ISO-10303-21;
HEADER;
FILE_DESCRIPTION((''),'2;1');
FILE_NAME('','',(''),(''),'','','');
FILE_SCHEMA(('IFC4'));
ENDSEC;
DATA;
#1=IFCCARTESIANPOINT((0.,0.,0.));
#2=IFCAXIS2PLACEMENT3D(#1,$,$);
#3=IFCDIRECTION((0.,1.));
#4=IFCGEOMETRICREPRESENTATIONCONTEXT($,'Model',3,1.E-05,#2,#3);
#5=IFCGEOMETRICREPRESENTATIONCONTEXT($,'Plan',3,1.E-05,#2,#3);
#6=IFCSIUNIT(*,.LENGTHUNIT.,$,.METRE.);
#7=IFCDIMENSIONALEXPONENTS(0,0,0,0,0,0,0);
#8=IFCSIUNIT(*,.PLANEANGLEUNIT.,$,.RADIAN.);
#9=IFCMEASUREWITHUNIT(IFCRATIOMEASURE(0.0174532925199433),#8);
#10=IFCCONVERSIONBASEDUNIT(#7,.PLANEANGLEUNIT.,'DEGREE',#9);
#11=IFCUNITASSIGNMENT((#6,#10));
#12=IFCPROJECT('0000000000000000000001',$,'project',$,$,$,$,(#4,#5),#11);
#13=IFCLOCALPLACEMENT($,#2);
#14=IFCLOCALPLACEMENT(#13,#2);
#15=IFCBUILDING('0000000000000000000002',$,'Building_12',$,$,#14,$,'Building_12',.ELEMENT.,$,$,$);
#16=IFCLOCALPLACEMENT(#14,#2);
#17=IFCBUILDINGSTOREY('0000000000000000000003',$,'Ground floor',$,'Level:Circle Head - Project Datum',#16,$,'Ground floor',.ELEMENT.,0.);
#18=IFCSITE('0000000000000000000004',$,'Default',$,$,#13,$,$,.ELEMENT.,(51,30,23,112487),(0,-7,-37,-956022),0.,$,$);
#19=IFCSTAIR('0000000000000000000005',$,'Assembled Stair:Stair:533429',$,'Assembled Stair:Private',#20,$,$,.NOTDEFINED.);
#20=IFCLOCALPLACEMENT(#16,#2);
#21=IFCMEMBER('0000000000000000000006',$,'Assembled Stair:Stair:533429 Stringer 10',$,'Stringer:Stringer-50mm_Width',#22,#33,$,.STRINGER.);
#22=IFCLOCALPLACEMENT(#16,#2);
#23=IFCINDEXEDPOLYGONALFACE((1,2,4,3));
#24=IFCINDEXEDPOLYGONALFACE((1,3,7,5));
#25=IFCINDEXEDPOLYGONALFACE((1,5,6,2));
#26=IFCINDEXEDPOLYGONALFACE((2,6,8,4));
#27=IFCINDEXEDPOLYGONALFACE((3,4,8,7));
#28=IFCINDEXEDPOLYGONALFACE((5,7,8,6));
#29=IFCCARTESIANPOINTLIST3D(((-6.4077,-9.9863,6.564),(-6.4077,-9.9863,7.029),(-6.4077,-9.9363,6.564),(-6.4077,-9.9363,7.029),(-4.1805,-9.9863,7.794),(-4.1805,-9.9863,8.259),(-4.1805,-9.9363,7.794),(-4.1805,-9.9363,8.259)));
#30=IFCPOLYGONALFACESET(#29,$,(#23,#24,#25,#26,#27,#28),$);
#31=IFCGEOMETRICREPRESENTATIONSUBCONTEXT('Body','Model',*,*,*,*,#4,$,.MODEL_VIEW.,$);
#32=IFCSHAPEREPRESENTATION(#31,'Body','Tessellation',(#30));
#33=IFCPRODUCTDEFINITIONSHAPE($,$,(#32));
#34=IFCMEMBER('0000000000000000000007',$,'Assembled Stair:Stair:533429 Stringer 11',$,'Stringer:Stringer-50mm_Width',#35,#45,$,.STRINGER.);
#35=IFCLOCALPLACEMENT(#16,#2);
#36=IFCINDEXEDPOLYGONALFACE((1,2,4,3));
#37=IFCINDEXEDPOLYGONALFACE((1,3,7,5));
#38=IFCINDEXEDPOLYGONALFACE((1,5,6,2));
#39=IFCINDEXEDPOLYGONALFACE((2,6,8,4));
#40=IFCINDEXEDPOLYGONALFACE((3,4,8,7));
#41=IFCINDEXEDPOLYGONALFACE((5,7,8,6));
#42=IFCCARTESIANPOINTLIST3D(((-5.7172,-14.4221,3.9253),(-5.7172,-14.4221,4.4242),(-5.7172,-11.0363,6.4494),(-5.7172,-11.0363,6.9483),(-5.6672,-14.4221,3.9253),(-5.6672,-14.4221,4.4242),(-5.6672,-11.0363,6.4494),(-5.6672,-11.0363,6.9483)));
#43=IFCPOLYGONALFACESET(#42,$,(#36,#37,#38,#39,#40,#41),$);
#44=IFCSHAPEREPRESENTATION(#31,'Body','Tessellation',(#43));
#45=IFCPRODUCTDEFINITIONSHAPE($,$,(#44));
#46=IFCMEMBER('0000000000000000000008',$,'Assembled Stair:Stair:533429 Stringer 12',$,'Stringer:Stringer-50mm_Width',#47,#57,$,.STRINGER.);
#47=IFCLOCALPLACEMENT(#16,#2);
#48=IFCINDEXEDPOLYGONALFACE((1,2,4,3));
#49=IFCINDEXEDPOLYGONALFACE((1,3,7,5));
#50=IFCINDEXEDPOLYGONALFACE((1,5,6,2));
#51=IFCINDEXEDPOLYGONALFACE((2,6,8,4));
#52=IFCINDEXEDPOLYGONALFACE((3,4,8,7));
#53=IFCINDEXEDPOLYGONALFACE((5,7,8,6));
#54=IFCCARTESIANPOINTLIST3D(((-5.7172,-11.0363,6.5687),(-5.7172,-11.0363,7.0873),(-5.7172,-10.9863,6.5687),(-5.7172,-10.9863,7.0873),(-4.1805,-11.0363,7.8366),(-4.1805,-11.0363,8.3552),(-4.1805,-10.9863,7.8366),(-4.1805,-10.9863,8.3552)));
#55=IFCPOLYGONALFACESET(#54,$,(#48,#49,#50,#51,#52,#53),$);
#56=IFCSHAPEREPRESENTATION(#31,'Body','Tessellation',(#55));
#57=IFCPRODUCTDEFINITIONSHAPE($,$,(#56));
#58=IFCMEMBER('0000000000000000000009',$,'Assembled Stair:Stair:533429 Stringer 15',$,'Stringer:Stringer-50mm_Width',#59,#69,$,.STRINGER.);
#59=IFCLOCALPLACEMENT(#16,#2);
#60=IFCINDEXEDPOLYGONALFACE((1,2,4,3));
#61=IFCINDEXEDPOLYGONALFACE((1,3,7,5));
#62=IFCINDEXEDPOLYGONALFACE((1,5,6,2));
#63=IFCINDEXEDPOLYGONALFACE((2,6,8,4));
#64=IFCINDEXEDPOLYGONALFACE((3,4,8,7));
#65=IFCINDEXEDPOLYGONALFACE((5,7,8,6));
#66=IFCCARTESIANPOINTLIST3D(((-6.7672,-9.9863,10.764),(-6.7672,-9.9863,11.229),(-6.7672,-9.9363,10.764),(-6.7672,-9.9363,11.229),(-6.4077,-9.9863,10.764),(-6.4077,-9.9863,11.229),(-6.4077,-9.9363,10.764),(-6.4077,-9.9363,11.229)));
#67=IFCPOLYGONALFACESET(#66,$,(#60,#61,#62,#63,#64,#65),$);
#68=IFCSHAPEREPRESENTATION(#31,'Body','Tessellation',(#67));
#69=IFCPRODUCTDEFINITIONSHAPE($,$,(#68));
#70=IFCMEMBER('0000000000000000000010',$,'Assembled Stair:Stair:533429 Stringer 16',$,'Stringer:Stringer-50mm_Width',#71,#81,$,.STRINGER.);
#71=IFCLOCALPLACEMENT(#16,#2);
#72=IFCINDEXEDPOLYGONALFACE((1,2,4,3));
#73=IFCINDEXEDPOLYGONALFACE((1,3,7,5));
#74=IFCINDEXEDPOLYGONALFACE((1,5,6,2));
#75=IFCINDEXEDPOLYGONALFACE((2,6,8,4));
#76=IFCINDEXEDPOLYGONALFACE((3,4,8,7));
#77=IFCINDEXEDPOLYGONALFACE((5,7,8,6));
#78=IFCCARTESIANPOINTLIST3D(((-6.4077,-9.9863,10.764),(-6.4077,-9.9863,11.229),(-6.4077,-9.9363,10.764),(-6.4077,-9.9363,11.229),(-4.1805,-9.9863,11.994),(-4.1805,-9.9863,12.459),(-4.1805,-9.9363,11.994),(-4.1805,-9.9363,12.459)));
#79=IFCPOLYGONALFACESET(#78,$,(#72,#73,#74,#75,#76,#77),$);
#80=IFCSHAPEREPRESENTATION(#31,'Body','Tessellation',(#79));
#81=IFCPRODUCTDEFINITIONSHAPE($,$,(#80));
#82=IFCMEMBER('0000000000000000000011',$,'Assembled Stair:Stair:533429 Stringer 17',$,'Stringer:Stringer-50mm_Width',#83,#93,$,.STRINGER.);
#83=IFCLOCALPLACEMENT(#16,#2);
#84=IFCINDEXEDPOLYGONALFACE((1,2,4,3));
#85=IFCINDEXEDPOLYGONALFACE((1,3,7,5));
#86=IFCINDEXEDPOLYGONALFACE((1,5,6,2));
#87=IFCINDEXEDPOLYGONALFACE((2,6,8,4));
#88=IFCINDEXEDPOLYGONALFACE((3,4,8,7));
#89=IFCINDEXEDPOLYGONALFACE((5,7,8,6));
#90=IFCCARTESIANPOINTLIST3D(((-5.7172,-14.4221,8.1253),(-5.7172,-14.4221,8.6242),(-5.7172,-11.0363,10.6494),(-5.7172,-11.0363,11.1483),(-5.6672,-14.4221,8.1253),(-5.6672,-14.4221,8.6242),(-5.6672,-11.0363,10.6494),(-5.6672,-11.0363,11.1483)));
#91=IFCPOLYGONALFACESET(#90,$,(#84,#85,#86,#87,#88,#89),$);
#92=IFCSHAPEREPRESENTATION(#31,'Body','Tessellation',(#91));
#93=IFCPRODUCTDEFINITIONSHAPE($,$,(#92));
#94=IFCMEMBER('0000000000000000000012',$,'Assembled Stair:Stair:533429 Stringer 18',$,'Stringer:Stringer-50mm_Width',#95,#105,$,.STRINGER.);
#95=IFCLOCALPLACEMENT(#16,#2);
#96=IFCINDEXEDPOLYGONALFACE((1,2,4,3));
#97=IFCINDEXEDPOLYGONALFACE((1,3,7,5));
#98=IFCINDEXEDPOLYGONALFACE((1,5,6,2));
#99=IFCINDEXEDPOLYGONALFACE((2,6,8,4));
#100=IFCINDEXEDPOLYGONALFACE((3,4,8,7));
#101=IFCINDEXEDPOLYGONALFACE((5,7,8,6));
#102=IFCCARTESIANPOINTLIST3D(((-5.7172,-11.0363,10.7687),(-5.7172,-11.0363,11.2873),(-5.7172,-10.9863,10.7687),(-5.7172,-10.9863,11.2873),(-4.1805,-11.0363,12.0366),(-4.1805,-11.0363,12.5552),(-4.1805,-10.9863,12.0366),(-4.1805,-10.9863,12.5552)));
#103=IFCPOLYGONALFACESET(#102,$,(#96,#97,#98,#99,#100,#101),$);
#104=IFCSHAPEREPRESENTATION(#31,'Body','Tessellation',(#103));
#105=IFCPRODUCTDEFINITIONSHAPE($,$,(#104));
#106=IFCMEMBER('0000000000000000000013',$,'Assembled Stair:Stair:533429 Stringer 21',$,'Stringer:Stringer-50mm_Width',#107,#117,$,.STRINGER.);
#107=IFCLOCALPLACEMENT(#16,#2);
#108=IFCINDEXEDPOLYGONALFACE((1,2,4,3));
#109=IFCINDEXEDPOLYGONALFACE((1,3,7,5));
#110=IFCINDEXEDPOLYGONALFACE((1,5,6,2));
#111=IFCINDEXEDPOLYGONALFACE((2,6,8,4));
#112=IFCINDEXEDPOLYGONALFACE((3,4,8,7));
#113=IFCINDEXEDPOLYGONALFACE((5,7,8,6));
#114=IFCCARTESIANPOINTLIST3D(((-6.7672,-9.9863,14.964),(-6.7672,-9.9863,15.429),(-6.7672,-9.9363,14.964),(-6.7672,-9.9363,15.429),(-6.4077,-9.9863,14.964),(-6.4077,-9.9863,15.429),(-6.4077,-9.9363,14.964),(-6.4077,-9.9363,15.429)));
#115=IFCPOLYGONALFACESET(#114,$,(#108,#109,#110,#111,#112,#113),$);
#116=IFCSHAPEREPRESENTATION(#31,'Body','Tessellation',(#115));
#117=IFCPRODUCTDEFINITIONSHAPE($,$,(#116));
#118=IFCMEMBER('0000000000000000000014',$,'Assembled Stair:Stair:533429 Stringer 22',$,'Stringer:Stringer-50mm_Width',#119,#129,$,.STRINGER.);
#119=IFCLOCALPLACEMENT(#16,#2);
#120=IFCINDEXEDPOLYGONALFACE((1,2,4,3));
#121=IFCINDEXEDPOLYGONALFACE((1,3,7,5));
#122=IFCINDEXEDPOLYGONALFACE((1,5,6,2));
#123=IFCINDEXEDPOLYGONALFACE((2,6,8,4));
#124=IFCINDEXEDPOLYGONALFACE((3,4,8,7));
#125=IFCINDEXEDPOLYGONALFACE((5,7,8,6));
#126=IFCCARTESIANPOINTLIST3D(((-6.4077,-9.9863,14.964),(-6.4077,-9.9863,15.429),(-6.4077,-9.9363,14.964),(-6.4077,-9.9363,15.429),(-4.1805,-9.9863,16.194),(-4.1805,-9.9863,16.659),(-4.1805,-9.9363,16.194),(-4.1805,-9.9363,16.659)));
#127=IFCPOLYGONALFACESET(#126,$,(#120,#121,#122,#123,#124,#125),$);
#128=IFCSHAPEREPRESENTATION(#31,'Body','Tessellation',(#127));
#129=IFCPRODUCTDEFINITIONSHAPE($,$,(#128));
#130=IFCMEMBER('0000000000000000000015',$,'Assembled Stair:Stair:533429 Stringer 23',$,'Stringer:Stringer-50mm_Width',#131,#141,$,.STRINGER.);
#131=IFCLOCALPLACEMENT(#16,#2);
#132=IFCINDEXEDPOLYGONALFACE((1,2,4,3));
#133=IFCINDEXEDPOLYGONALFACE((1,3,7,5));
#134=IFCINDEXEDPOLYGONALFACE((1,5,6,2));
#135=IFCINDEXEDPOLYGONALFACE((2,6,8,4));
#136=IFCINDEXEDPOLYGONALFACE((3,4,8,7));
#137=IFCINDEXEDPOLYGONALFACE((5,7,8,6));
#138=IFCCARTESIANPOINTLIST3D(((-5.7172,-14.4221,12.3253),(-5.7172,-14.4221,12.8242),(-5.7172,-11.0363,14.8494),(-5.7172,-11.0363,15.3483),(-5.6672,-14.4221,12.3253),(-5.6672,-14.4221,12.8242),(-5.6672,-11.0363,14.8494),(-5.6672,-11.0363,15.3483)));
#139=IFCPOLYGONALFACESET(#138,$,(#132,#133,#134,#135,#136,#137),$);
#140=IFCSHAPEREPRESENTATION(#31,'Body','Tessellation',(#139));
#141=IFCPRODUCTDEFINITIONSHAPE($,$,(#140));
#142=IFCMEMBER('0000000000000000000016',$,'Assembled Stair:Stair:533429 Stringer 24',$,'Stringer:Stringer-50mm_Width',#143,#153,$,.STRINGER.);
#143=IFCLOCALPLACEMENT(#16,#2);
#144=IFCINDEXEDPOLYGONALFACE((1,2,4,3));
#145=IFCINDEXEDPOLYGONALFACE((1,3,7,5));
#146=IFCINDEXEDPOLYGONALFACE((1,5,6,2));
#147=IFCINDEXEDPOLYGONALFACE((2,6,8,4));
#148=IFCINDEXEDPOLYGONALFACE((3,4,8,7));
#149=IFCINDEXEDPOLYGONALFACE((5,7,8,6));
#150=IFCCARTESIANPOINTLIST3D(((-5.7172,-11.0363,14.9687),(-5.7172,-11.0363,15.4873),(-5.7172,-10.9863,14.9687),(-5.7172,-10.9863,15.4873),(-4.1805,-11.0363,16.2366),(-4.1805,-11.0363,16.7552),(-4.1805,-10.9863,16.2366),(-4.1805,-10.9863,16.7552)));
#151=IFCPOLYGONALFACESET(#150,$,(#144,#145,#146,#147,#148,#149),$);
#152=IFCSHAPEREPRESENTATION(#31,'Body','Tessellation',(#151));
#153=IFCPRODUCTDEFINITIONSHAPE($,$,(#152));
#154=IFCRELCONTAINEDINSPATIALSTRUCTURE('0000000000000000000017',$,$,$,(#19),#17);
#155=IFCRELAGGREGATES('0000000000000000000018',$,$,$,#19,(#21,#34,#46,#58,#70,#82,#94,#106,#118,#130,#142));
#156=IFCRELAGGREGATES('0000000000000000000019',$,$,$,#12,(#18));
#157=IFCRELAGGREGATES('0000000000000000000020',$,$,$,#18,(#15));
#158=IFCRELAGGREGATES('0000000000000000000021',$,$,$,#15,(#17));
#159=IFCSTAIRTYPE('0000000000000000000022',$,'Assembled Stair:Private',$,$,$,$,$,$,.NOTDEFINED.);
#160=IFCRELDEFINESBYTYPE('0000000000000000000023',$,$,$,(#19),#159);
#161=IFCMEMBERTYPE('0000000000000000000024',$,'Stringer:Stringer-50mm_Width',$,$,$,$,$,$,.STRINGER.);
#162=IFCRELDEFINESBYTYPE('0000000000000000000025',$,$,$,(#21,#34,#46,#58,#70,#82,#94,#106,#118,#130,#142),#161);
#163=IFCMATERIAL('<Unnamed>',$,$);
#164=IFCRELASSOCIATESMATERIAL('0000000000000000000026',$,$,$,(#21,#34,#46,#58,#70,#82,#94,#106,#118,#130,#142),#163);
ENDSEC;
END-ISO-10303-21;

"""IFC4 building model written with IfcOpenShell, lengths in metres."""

from ifc_helpers import new_model, entity, si_unit, converted_unit, direction, frame, origin, place, context, subcontext, project, spatial, indexed_curve, outline, extrude, material, type_object, element, aggregate, save


model = new_model("IFC4")

# Units and contexts
model_context = context("Model", 3, precision=1e-05, world=origin(), true_north=direction((0.0, 1.0)))
plan_context = context("Plan", 3, precision=1e-05, world=origin(), true_north=direction((0.0, 1.0)))
body_context = subcontext(model_context, "Body", "Model", "MODEL_VIEW")
ifc_project = project(units=[si_unit("LENGTHUNIT", "METRE"), converted_unit("PLANEANGLEUNIT", "DEGREE", entity("IfcRatioMeasure", 0.0174532925199433), si_unit("PLANEANGLEUNIT", "RADIAN"), dimensions=[0, 0, 0, 0, 0, 0, 0])], contexts=[model_context, plan_context])

# Site, building, storey
site_placement = place(None, origin())
site = spatial("IfcSite", under=ifc_project, at=site_placement, Name="Default", CompositionType="ELEMENT", RefLatitude=(51, 30, 23, 112487), RefLongitude=(0, -7, -37, -956022), RefElevation=0.0)
building_placement = place(site_placement, origin())
building = spatial("IfcBuilding", under=site, at=building_placement, Name="Building_12", LongName="Building_12", CompositionType="ELEMENT")
storey_placement = place(building_placement, origin())
storey = spatial("IfcBuildingStorey", under=building, at=storey_placement, Name="Ground floor", ObjectType="Level:Circle Head - Project Datum", LongName="Ground floor", CompositionType="ELEMENT", Elevation=0.0)

# Stair, members
stair_type = type_object("IfcStairType", Name="Assembled Stair:Private", PredefinedType="NOTDEFINED")
stair_placement = place(storey_placement, origin())
stair = element("IfcStair", 1, at=stair_placement, inside=storey, type_object=stair_type, Name="Assembled Stair:Stair:533429", ObjectType="Assembled Stair:Private", PredefinedType="NOTDEFINED")
ifc_material_1 = material(Name="<Unnamed>")
member_type = type_object("IfcMemberType", Name="Stringer:Stringer-50mm_Width", PredefinedType="STRINGER")
member_1_placement = place(stair_placement, origin())
member_1 = element("IfcMember", 2, at=member_1_placement, type_object=member_type, material=ifc_material_1, Name="Assembled Stair:Stair:533429 Stringer 10", ObjectType="Stringer:Stringer-50mm_Width", PredefinedType="STRINGER", context=body_context, shape_type="SweptSolid", body=[
    extrude(outline(indexed_curve([(-1.1598, -0.2035), (1.3846, -0.2035), (1.1598, 0.2035), (-1.3846, 0.2035), (-1.1598, -0.2035)], self_intersect=False)), frame((-5.2941, -9.9863, 7.4115), z_axis=(0.0, 1.0, 0.0), x_axis=(0.87537, 0.0, 0.483454)), (0.0, 0.0, 1.0), 0.05),
])
member_2_placement = place(stair_placement, origin())
member_2 = element("IfcMember", 3, at=member_2_placement, type_object=member_type, material=ifc_material_1, Name="Assembled Stair:Stair:533429 Stringer 11", ObjectType="Stringer:Stringer-50mm_Width", PredefinedType="STRINGER", context=body_context, shape_type="SweptSolid", body=[
    extrude(outline(indexed_curve([(-2.2606, -0.2), (1.9624, -0.2), (2.2606, 0.2), (-1.9624, 0.2), (-2.2606, -0.2)], self_intersect=False)), frame((-5.7172, -12.7292, 5.4368), z_axis=(1.0, 0.0, 0.0), x_axis=(0.0, 0.801728, 0.597689)), (0.0, 0.0, 1.0), 0.05),
])
member_3_placement = place(stair_placement, origin())
member_3 = element("IfcMember", 4, at=member_3_placement, type_object=member_type, material=ifc_material_1, Name="Assembled Stair:Stair:533429 Stringer 12", ObjectType="Stringer:Stringer-50mm_Width", PredefinedType="STRINGER", context=body_context, shape_type="SweptSolid", body=[
    extrude(outline(indexed_curve([(-0.8311, -0.2), (1.1612, -0.2), (0.8311, 0.2), (-1.1612, 0.2), (-0.8311, -0.2)], self_intersect=False)), frame((-4.9488, -11.0363, 7.462), z_axis=(0.0, 1.0, 0.0), x_axis=(0.771336, 0.0, 0.636428)), (0.0, 0.0, 1.0), 0.05),
])
member_4_placement = place(stair_placement, origin())
member_4 = element("IfcMember", 5, at=member_4_placement, type_object=member_type, material=ifc_material_1, Name="Assembled Stair:Stair:533429 Stringer 15", ObjectType="Stringer:Stringer-50mm_Width", PredefinedType="STRINGER", context=body_context, shape_type="SweptSolid", body=[
    extrude(outline(indexed_curve([(-0.1797, -0.025), (0.1797, -0.025), (0.1797, 0.025), (-0.1797, 0.025), (-0.1797, -0.025)], self_intersect=False)), frame((-6.5874, -9.9613, 10.764)), (0.0, 0.0, 1.0), 0.465),
])
member_5_placement = place(stair_placement, origin())
member_5 = element("IfcMember", 6, at=member_5_placement, type_object=member_type, material=ifc_material_1, Name="Assembled Stair:Stair:533429 Stringer 16", ObjectType="Stringer:Stringer-50mm_Width", PredefinedType="STRINGER", context=body_context, shape_type="SweptSolid", body=[
    extrude(outline(indexed_curve([(-1.1598, -0.2035), (1.3846, -0.2035), (1.1598, 0.2035), (-1.3846, 0.2035), (-1.1598, -0.2035)], self_intersect=False)), frame((-5.2941, -9.9863, 11.6115), z_axis=(0.0, 1.0, 0.0), x_axis=(0.87537, 0.0, 0.483454)), (0.0, 0.0, 1.0), 0.05),
])
member_6_placement = place(stair_placement, origin())
member_6 = element("IfcMember", 7, at=member_6_placement, type_object=member_type, material=ifc_material_1, Name="Assembled Stair:Stair:533429 Stringer 17", ObjectType="Stringer:Stringer-50mm_Width", PredefinedType="STRINGER", context=body_context, shape_type="SweptSolid", body=[
    extrude(outline(indexed_curve([(-2.2606, -0.2), (1.9624, -0.2), (2.2606, 0.2), (-1.9624, 0.2), (-2.2606, -0.2)], self_intersect=False)), frame((-5.7172, -12.7292, 9.6368), z_axis=(1.0, 0.0, 0.0), x_axis=(0.0, 0.801728, 0.597689)), (0.0, 0.0, 1.0), 0.05),
])
member_7_placement = place(stair_placement, origin())
member_7 = element("IfcMember", 8, at=member_7_placement, type_object=member_type, material=ifc_material_1, Name="Assembled Stair:Stair:533429 Stringer 18", ObjectType="Stringer:Stringer-50mm_Width", PredefinedType="STRINGER", context=body_context, shape_type="SweptSolid", body=[
    extrude(outline(indexed_curve([(-0.8311, -0.2), (1.1612, -0.2), (0.8311, 0.2), (-1.1612, 0.2), (-0.8311, -0.2)], self_intersect=False)), frame((-4.9488, -11.0363, 11.662), z_axis=(0.0, 1.0, 0.0), x_axis=(0.771336, 0.0, 0.636428)), (0.0, 0.0, 1.0), 0.05),
])
member_8_placement = place(stair_placement, origin())
member_8 = element("IfcMember", 9, at=member_8_placement, type_object=member_type, material=ifc_material_1, Name="Assembled Stair:Stair:533429 Stringer 21", ObjectType="Stringer:Stringer-50mm_Width", PredefinedType="STRINGER", context=body_context, shape_type="SweptSolid", body=[
    extrude(outline(indexed_curve([(-0.1797, -0.025), (0.1797, -0.025), (0.1797, 0.025), (-0.1797, 0.025), (-0.1797, -0.025)], self_intersect=False)), frame((-6.5874, -9.9613, 14.964)), (0.0, 0.0, 1.0), 0.465),
])
member_9_placement = place(stair_placement, origin())
member_9 = element("IfcMember", 10, at=member_9_placement, type_object=member_type, material=ifc_material_1, Name="Assembled Stair:Stair:533429 Stringer 22", ObjectType="Stringer:Stringer-50mm_Width", PredefinedType="STRINGER", context=body_context, shape_type="SweptSolid", body=[
    extrude(outline(indexed_curve([(-1.1598, -0.2035), (1.3846, -0.2035), (1.1598, 0.2035), (-1.3846, 0.2035), (-1.1598, -0.2035)], self_intersect=False)), frame((-5.2941, -9.9863, 15.8115), z_axis=(0.0, 1.0, 0.0), x_axis=(0.87537, 0.0, 0.483454)), (0.0, 0.0, 1.0), 0.05),
])
member_10_placement = place(stair_placement, origin())
member_10 = element("IfcMember", 11, at=member_10_placement, type_object=member_type, material=ifc_material_1, Name="Assembled Stair:Stair:533429 Stringer 23", ObjectType="Stringer:Stringer-50mm_Width", PredefinedType="STRINGER", context=body_context, shape_type="SweptSolid", body=[
    extrude(outline(indexed_curve([(-2.2606, -0.2), (1.9624, -0.2), (2.2606, 0.2), (-1.9624, 0.2), (-2.2606, -0.2)], self_intersect=False)), frame((-5.7172, -12.7292, 13.8368), z_axis=(1.0, 0.0, 0.0), x_axis=(0.0, 0.801728, 0.597689)), (0.0, 0.0, 1.0), 0.05),
])
member_11_placement = place(stair_placement, origin())
member_11 = element("IfcMember", 12, at=member_11_placement, type_object=member_type, material=ifc_material_1, Name="Assembled Stair:Stair:533429 Stringer 24", ObjectType="Stringer:Stringer-50mm_Width", PredefinedType="STRINGER", context=body_context, shape_type="SweptSolid", body=[
    extrude(outline(indexed_curve([(-0.8311, -0.2), (1.1612, -0.2), (0.8311, 0.2), (-1.1612, 0.2), (-0.8311, -0.2)], self_intersect=False)), frame((-4.9488, -11.0363, 15.862), z_axis=(0.0, 1.0, 0.0), x_axis=(0.771336, 0.0, 0.636428)), (0.0, 0.0, 1.0), 0.05),
])
aggregate(stair, [member_1, member_2, member_3, member_4, member_5, member_6, member_7, member_8, member_9, member_10, member_11])

save(model, "model.ifc")
